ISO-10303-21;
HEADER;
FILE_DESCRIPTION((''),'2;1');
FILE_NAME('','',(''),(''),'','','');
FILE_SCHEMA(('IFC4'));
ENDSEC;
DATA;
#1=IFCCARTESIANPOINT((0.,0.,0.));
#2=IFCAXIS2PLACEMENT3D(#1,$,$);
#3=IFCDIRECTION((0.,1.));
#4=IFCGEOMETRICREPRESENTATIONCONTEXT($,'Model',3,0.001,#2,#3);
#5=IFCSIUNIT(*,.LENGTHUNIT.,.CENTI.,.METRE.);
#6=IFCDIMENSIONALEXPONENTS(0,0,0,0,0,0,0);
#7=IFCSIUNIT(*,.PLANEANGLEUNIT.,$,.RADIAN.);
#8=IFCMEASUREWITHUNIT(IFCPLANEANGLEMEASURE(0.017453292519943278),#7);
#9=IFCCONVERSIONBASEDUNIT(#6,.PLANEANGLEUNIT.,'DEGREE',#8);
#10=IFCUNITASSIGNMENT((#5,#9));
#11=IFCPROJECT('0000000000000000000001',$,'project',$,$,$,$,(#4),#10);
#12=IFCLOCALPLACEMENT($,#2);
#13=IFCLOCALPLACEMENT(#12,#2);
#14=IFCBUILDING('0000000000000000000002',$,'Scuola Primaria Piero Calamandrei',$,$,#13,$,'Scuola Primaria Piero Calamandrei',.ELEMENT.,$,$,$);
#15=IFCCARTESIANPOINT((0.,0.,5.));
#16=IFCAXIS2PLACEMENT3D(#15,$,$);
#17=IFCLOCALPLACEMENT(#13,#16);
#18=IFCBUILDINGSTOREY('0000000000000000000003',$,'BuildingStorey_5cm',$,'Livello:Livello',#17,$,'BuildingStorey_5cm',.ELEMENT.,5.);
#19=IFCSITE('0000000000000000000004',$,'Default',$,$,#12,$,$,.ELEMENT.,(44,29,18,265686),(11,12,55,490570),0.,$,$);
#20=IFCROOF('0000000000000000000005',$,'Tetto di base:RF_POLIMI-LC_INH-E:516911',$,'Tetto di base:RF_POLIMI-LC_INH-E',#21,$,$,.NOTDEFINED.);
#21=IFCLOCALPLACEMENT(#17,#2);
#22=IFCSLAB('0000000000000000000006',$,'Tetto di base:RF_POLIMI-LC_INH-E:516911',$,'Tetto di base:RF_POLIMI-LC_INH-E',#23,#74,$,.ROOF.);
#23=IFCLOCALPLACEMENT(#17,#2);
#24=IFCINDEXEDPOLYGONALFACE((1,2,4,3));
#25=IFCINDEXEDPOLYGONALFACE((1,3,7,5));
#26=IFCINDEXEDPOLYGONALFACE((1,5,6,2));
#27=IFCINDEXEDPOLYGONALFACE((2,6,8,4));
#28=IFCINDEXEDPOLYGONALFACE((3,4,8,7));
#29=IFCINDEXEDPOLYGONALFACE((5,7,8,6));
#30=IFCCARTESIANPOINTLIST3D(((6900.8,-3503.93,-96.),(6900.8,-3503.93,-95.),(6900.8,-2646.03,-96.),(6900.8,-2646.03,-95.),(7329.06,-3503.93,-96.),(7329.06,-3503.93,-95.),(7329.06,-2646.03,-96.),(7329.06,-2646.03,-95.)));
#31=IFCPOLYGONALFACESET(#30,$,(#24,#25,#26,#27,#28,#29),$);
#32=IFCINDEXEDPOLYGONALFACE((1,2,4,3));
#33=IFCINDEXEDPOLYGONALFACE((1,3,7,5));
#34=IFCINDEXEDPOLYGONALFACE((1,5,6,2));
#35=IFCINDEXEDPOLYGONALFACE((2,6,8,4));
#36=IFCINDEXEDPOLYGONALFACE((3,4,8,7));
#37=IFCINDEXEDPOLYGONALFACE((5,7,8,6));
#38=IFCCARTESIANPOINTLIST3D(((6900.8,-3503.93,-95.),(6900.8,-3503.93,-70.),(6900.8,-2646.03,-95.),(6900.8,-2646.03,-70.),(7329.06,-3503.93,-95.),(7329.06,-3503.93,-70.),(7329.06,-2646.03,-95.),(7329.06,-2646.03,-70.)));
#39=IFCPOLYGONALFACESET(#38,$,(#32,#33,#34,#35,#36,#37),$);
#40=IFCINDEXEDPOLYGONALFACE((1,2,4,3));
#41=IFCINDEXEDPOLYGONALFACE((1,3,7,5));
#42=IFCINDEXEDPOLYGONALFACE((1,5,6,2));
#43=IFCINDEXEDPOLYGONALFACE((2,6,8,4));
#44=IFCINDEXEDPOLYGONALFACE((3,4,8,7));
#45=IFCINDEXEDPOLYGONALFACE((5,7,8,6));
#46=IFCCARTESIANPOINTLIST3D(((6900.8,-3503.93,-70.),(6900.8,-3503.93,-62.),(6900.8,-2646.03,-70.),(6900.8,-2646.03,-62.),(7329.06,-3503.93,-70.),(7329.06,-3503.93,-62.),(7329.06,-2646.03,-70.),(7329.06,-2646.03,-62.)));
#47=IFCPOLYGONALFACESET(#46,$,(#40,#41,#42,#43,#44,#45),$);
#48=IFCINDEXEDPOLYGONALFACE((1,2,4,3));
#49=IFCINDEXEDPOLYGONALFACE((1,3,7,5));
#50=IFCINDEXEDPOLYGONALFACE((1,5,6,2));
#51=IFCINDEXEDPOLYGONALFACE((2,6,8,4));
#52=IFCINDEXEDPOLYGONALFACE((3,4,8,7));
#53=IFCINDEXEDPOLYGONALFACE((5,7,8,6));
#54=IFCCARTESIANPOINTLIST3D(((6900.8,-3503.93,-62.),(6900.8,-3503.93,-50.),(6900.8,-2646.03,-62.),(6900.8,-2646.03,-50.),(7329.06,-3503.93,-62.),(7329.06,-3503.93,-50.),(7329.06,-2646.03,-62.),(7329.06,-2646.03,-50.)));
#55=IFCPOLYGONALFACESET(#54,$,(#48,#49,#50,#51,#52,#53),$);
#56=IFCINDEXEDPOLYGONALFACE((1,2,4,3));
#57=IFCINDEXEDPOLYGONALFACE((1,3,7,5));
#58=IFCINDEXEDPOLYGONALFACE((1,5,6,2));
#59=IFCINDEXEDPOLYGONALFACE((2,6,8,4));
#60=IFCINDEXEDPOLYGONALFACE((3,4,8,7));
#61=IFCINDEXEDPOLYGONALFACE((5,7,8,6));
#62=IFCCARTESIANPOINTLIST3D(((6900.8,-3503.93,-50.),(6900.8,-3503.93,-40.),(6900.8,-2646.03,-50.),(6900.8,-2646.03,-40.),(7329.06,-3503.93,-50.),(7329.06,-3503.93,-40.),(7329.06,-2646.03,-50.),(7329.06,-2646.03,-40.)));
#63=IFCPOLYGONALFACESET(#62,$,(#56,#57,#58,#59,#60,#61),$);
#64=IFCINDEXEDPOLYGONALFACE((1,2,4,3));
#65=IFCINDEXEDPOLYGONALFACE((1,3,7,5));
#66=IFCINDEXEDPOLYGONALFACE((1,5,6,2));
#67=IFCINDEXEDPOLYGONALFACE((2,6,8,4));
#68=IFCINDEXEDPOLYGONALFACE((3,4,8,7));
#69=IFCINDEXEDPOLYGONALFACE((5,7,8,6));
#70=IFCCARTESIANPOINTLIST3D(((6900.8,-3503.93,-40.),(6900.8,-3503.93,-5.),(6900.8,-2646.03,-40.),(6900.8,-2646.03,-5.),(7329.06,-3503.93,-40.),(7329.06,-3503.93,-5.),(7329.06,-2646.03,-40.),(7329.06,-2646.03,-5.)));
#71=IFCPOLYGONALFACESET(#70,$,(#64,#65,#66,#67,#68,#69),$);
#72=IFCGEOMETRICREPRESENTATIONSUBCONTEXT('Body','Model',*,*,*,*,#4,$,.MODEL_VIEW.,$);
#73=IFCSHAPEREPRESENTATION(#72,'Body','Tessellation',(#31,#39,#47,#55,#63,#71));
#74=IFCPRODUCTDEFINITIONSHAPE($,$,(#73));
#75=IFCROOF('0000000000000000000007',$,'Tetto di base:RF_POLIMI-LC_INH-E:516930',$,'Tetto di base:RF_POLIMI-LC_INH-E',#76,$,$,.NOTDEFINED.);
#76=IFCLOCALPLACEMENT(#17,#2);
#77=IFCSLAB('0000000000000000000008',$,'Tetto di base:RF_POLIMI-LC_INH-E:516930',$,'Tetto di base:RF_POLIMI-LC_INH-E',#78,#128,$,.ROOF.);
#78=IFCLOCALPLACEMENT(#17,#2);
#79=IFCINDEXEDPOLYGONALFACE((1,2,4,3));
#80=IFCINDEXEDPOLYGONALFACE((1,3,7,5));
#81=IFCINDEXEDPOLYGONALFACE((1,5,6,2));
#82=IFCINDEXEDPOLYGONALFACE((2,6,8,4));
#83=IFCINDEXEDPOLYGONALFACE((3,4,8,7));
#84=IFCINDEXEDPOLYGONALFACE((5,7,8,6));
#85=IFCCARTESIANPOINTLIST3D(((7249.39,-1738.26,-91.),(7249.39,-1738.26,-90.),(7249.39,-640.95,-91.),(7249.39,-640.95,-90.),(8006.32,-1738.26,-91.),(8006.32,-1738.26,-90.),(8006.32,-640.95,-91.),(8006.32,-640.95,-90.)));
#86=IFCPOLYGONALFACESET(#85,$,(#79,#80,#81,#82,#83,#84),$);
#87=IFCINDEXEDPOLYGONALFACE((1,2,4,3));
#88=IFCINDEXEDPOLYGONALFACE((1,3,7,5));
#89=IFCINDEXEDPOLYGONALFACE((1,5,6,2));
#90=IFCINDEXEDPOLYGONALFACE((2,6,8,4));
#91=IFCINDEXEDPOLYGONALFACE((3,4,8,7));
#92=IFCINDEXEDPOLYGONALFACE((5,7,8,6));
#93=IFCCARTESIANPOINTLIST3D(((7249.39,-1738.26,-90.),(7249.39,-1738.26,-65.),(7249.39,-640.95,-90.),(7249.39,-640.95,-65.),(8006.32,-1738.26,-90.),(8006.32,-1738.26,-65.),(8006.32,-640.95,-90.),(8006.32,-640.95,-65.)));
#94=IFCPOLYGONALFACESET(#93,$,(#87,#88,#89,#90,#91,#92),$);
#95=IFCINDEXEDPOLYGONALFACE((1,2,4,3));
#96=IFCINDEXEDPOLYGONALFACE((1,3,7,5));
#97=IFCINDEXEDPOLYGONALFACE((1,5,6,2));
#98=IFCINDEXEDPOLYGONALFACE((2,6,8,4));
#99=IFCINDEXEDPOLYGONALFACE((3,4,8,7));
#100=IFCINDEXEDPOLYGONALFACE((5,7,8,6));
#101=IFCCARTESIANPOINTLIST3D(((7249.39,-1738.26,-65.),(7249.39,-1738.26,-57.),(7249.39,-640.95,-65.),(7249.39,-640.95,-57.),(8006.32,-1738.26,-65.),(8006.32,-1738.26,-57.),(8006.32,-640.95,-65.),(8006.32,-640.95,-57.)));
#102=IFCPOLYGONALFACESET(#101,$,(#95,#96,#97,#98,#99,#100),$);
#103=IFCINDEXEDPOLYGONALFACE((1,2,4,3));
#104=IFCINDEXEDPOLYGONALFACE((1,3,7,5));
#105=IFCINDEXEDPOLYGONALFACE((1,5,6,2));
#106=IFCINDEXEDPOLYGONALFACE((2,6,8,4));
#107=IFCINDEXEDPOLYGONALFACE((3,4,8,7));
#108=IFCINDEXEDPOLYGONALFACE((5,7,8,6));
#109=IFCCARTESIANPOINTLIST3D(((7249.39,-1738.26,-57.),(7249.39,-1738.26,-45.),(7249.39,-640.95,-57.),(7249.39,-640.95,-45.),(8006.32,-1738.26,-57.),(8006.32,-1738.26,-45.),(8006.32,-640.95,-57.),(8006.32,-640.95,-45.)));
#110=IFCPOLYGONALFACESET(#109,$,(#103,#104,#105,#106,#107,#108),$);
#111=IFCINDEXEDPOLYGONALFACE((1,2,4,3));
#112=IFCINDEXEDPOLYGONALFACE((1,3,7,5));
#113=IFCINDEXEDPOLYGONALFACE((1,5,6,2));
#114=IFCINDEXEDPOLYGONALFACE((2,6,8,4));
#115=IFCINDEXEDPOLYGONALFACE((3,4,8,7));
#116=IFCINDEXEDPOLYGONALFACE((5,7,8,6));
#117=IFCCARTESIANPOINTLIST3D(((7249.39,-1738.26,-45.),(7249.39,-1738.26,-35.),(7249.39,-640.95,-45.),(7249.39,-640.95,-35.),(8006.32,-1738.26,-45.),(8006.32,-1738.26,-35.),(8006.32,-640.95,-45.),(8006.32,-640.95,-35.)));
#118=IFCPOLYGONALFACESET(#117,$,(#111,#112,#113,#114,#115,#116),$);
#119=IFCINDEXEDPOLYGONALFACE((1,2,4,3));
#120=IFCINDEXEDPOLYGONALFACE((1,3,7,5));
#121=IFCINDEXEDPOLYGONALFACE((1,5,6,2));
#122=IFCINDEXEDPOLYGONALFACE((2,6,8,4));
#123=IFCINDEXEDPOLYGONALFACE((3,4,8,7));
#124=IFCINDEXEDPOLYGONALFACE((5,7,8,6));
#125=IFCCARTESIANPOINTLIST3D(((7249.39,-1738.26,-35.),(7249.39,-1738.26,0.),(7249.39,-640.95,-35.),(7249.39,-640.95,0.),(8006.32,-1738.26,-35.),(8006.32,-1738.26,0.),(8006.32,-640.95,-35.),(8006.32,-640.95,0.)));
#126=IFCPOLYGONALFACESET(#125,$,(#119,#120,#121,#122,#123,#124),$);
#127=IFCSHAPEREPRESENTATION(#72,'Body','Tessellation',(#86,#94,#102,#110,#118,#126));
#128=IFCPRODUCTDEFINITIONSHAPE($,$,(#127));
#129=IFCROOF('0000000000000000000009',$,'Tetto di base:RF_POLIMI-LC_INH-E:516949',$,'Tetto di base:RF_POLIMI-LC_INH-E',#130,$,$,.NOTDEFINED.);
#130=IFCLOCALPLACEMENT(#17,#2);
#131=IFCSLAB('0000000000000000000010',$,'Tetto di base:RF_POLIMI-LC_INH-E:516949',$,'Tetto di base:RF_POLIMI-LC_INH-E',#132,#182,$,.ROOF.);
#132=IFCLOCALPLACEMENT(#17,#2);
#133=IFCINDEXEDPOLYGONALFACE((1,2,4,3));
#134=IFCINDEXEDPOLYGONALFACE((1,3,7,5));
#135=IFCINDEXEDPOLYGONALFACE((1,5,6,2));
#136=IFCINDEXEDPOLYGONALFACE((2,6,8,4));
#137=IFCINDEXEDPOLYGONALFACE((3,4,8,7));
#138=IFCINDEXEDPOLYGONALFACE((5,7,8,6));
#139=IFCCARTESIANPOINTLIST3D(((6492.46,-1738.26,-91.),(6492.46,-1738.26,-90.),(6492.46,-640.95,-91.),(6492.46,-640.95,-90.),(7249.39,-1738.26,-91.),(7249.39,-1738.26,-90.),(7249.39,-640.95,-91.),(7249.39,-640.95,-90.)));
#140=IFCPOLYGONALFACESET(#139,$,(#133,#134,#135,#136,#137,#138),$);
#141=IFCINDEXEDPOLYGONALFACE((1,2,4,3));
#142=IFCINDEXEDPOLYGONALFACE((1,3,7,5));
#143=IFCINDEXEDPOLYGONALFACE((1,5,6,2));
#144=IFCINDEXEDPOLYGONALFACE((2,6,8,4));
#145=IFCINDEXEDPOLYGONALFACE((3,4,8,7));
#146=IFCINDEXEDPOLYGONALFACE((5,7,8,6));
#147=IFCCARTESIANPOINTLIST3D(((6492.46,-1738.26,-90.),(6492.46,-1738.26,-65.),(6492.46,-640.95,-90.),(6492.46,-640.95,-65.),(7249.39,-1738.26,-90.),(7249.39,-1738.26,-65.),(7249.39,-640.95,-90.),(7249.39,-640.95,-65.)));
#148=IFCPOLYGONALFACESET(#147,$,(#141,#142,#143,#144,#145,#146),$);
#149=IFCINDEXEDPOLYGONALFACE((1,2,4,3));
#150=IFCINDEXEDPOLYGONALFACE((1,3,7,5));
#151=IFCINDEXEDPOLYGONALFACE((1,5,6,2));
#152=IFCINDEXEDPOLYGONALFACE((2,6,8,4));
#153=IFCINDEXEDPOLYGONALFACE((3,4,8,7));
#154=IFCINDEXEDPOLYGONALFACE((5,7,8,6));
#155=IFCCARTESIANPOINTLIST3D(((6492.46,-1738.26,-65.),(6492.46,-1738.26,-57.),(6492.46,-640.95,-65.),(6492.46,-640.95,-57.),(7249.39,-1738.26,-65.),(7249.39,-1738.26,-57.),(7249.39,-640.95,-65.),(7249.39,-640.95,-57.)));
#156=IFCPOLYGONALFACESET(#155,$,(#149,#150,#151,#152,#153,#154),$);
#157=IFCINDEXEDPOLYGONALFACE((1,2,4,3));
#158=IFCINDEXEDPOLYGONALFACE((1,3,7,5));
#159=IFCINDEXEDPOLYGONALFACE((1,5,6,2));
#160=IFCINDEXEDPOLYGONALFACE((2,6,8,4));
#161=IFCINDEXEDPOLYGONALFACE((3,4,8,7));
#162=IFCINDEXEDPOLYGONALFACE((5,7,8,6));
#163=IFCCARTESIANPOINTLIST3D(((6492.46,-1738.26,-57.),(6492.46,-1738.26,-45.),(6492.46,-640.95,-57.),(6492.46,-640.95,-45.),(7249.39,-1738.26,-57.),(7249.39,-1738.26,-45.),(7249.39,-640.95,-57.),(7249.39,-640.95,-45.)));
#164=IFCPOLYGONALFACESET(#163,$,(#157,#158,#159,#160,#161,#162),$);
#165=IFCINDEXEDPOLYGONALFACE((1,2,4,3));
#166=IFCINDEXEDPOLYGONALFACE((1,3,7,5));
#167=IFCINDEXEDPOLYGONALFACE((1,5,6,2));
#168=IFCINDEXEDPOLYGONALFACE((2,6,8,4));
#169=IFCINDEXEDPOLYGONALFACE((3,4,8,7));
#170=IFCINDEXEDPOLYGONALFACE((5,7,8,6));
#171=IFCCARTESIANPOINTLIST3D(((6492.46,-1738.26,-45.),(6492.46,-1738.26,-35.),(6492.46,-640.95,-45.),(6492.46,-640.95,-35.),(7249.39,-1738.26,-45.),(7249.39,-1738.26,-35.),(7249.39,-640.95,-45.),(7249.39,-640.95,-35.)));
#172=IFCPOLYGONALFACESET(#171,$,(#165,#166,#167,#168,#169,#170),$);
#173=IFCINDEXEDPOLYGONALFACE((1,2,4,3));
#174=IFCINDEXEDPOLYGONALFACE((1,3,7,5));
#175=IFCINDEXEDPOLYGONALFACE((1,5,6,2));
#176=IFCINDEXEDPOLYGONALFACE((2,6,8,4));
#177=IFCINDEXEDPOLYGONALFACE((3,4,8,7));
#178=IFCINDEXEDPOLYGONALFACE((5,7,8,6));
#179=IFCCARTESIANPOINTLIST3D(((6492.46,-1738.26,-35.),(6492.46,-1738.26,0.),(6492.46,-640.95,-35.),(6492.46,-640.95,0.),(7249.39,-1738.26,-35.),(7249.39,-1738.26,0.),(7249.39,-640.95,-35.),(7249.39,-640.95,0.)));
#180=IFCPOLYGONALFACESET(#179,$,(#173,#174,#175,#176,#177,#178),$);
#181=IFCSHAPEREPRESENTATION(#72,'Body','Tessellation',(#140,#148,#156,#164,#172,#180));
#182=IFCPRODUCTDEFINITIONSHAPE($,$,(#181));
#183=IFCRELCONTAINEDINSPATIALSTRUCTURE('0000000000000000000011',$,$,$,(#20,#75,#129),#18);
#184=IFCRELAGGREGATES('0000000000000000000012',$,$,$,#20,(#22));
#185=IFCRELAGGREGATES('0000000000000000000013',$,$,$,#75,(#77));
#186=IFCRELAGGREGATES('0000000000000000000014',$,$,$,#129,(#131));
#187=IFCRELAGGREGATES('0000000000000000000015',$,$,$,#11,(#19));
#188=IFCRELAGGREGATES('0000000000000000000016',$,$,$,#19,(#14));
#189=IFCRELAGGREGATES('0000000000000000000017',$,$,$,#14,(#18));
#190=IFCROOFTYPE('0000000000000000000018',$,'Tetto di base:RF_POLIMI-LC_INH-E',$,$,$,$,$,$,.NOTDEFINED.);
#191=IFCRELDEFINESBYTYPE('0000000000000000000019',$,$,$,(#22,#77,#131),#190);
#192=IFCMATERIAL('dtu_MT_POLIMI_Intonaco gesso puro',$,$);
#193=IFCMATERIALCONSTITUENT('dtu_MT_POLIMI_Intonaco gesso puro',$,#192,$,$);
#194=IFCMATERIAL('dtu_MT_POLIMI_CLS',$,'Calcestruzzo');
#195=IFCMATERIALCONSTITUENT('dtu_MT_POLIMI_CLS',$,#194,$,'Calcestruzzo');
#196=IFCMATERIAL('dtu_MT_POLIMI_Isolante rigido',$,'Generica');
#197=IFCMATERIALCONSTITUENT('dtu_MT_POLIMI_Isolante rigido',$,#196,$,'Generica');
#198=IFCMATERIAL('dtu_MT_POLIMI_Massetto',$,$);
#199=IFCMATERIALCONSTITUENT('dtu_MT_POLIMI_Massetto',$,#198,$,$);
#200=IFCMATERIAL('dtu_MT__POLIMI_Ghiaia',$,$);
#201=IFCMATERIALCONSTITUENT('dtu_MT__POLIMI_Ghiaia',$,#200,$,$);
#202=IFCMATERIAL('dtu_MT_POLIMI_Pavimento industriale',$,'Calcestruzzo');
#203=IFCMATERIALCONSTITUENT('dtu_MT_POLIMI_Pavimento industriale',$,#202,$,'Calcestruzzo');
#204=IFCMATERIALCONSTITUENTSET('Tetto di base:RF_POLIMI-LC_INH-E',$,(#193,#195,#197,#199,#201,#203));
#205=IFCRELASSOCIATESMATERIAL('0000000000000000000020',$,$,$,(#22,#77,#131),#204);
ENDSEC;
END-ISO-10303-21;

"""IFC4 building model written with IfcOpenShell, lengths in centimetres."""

from ifc_helpers import new_model, entity, si_unit, converted_unit, direction, frame, origin, place, context, subcontext, project, spatial, indexed_curve, outline, extrude, material, constituent, constituent_set, type_object, element, aggregate, save


model = new_model("IFC4")

# Units and contexts
model_context = context("Model", 3, precision=0.001, world=origin(), true_north=direction((0.0, 1.0)))
body_context = subcontext(model_context, "Body", "Model", "MODEL_VIEW")
ifc_project = project(units=[si_unit("LENGTHUNIT", "METRE", prefix="CENTI"), converted_unit("PLANEANGLEUNIT", "DEGREE", entity("IfcPlaneAngleMeasure", 0.017453292519943278), si_unit("PLANEANGLEUNIT", "RADIAN"), dimensions=[0, 0, 0, 0, 0, 0, 0])], contexts=[model_context])

# Site, building, storey
site_placement = place(None, origin())
site = spatial("IfcSite", under=ifc_project, at=site_placement, Name="Default", CompositionType="ELEMENT", RefLatitude=(44, 29, 18, 265686), RefLongitude=(11, 12, 55, 490570), RefElevation=0.0)
building_placement = place(site_placement, origin())
building = spatial("IfcBuilding", under=site, at=building_placement, Name="Scuola Primaria Piero Calamandrei", LongName="Scuola Primaria Piero Calamandrei", CompositionType="ELEMENT")
storey_placement = place(building_placement, frame((0.0, 0.0, 5.0)))
storey = spatial("IfcBuildingStorey", under=building, at=storey_placement, Name="BuildingStorey_5cm", ObjectType="Livello:Livello", LongName="BuildingStorey_5cm", CompositionType="ELEMENT", Elevation=5.0)

# Roofs, slabs
roof_1_placement = place(storey_placement, frame((6900.8, -3503.93, -96.0)))
roof_1 = element("IfcRoof", 1, at=roof_1_placement, inside=storey, Name="Tetto di base:RF_POLIMI-LC_INH-E:516911", ObjectType="Tetto di base:RF_POLIMI-LC_INH-E", PredefinedType="NOTDEFINED")
ifc_material_1 = material(Name="dtu_MT_POLIMI_Intonaco gesso puro")
ifc_constituent_1 = constituent(ifc_material_1, Name="dtu_MT_POLIMI_Intonaco gesso puro")
ifc_material_2 = material(Name="dtu_MT_POLIMI_CLS", Category="Calcestruzzo")
ifc_constituent_2 = constituent(ifc_material_2, Name="dtu_MT_POLIMI_CLS", Category="Calcestruzzo")
ifc_material_3 = material(Name="dtu_MT_POLIMI_Isolante rigido", Category="Generica")
ifc_constituent_3 = constituent(ifc_material_3, Name="dtu_MT_POLIMI_Isolante rigido", Category="Generica")
ifc_material_4 = material(Name="dtu_MT_POLIMI_Massetto")
ifc_constituent_4 = constituent(ifc_material_4, Name="dtu_MT_POLIMI_Massetto")
ifc_material_5 = material(Name="dtu_MT__POLIMI_Ghiaia")
ifc_constituent_5 = constituent(ifc_material_5, Name="dtu_MT__POLIMI_Ghiaia")
ifc_material_6 = material(Name="dtu_MT_POLIMI_Pavimento industriale", Category="Calcestruzzo")
ifc_constituent_6 = constituent(ifc_material_6, Name="dtu_MT_POLIMI_Pavimento industriale", Category="Calcestruzzo")
ifc_constituent_set_1 = constituent_set(constituents=[ifc_constituent_1, ifc_constituent_2, ifc_constituent_3, ifc_constituent_4, ifc_constituent_5, ifc_constituent_6], Name="Tetto di base:RF_POLIMI-LC_INH-E")
roof_type = type_object("IfcRoofType", Name="Tetto di base:RF_POLIMI-LC_INH-E", PredefinedType="NOTDEFINED")
slab_1_placement = place(roof_1_placement, origin())
slab_1 = element("IfcSlab", 2, at=slab_1_placement, type_object=roof_type, material=ifc_constituent_set_1, Name="Tetto di base:RF_POLIMI-LC_INH-E:516911", ObjectType="Tetto di base:RF_POLIMI-LC_INH-E", PredefinedType="ROOF", context=body_context, shape_type="SweptSolid", body=[
    extrude(outline(indexed_curve([(214.13, -428.95), (214.13, 428.95), (-214.13, 428.95), (-214.13, -428.95), (214.13, -428.95)], self_intersect=False)), frame((214.13, 428.95, 0.0)), (0.0, 0.0, 1.0), 1.0),
    extrude(outline(indexed_curve([(214.13, -428.95), (214.13, 428.95), (-214.13, 428.95), (-214.13, -428.95), (214.13, -428.95)], self_intersect=False)), frame((214.13, 428.95, 1.0)), (0.0, 0.0, 1.0), 25.0),
    extrude(outline(indexed_curve([(214.13, -428.95), (214.13, 428.95), (-214.13, 428.95), (-214.13, -428.95), (214.13, -428.95)], self_intersect=False)), frame((214.13, 428.95, 26.0)), (0.0, 0.0, 1.0), 8.0),
    extrude(outline(indexed_curve([(214.13, -428.95), (214.13, 428.95), (-214.13, 428.95), (-214.13, -428.95), (214.13, -428.95)], self_intersect=False)), frame((214.13, 428.95, 34.0)), (0.0, 0.0, 1.0), 12.0),
    extrude(outline(indexed_curve([(214.13, -428.95), (214.13, 428.95), (-214.13, 428.95), (-214.13, -428.95), (214.13, -428.95)], self_intersect=False)), frame((214.13, 428.95, 46.0)), (0.0, 0.0, 1.0), 10.0),
    extrude(outline(indexed_curve([(214.13, -428.95), (214.13, 428.95), (-214.13, 428.95), (-214.13, -428.95), (214.13, -428.95)], self_intersect=False)), frame((214.13, 428.95, 56.0)), (0.0, 0.0, 1.0), 35.0),
])
aggregate(roof_1, [slab_1])
roof_2_placement = place(storey_placement, frame((7249.39, -1738.26, -91.0)))
roof_2 = element("IfcRoof", 3, at=roof_2_placement, inside=storey, Name="Tetto di base:RF_POLIMI-LC_INH-E:516930", ObjectType="Tetto di base:RF_POLIMI-LC_INH-E", PredefinedType="NOTDEFINED")
slab_2_placement = place(roof_2_placement, origin())
slab_2 = element("IfcSlab", 4, at=slab_2_placement, type_object=roof_type, material=ifc_constituent_set_1, Name="Tetto di base:RF_POLIMI-LC_INH-E:516930", ObjectType="Tetto di base:RF_POLIMI-LC_INH-E", PredefinedType="ROOF", context=body_context, shape_type="SweptSolid", body=[
    extrude(outline(indexed_curve([(-378.47, 548.66), (-378.47, -548.66), (378.47, -548.66), (378.47, 548.66), (-378.47, 548.66)], self_intersect=False)), frame((378.47, 548.66, 0.0)), (0.0, 0.0, 1.0), 1.0),
    extrude(outline(indexed_curve([(-378.47, 548.66), (-378.47, -548.66), (378.47, -548.66), (378.47, 548.66), (-378.47, 548.66)], self_intersect=False)), frame((378.47, 548.66, 1.0)), (0.0, 0.0, 1.0), 25.0),
    extrude(outline(indexed_curve([(-378.47, 548.66), (-378.47, -548.66), (378.47, -548.66), (378.47, 548.66), (-378.47, 548.66)], self_intersect=False)), frame((378.47, 548.66, 26.0)), (0.0, 0.0, 1.0), 8.0),
    extrude(outline(indexed_curve([(-378.47, 548.66), (-378.47, -548.66), (378.47, -548.66), (378.47, 548.66), (-378.47, 548.66)], self_intersect=False)), frame((378.47, 548.66, 34.0)), (0.0, 0.0, 1.0), 12.0),
    extrude(outline(indexed_curve([(-378.47, 548.66), (-378.47, -548.66), (378.47, -548.66), (378.47, 548.66), (-378.47, 548.66)], self_intersect=False)), frame((378.47, 548.66, 46.0)), (0.0, 0.0, 1.0), 10.0),
    extrude(outline(indexed_curve([(-378.47, 548.66), (-378.47, -548.66), (378.47, -548.66), (378.47, 548.66), (-378.47, 548.66)], self_intersect=False)), frame((378.47, 548.66, 56.0)), (0.0, 0.0, 1.0), 35.0),
])
aggregate(roof_2, [slab_2])
roof_3_placement = place(storey_placement, frame((6492.46, -1738.26, -91.0)))
roof_3 = element("IfcRoof", 5, at=roof_3_placement, inside=storey, Name="Tetto di base:RF_POLIMI-LC_INH-E:516949", ObjectType="Tetto di base:RF_POLIMI-LC_INH-E", PredefinedType="NOTDEFINED")
slab_3_placement = place(roof_3_placement, origin())
slab_3 = element("IfcSlab", 6, at=slab_3_placement, type_object=roof_type, material=ifc_constituent_set_1, Name="Tetto di base:RF_POLIMI-LC_INH-E:516949", ObjectType="Tetto di base:RF_POLIMI-LC_INH-E", PredefinedType="ROOF", context=body_context, shape_type="SweptSolid", body=[
    extrude(outline(indexed_curve([(378.47, 548.66), (-378.47, 548.66), (-378.47, -548.66), (378.47, -548.66), (378.47, 548.66)], self_intersect=False)), frame((378.47, 548.66, 0.0)), (0.0, 0.0, 1.0), 1.0),
    extrude(outline(indexed_curve([(378.47, 548.66), (-378.47, 548.66), (-378.47, -548.66), (378.47, -548.66), (378.47, 548.66)], self_intersect=False)), frame((378.47, 548.66, 1.0)), (0.0, 0.0, 1.0), 25.0),
    extrude(outline(indexed_curve([(378.47, 548.66), (-378.47, 548.66), (-378.47, -548.66), (378.47, -548.66), (378.47, 548.66)], self_intersect=False)), frame((378.47, 548.66, 26.0)), (0.0, 0.0, 1.0), 8.0),
    extrude(outline(indexed_curve([(378.47, 548.66), (-378.47, 548.66), (-378.47, -548.66), (378.47, -548.66), (378.47, 548.66)], self_intersect=False)), frame((378.47, 548.66, 34.0)), (0.0, 0.0, 1.0), 12.0),
    extrude(outline(indexed_curve([(378.47, 548.66), (-378.47, 548.66), (-378.47, -548.66), (378.47, -548.66), (378.47, 548.66)], self_intersect=False)), frame((378.47, 548.66, 46.0)), (0.0, 0.0, 1.0), 10.0),
    extrude(outline(indexed_curve([(378.47, 548.66), (-378.47, 548.66), (-378.47, -548.66), (378.47, -548.66), (378.47, 548.66)], self_intersect=False)), frame((378.47, 548.66, 56.0)), (0.0, 0.0, 1.0), 35.0),
])
aggregate(roof_3, [slab_3])

save(model, "model.ifc")
